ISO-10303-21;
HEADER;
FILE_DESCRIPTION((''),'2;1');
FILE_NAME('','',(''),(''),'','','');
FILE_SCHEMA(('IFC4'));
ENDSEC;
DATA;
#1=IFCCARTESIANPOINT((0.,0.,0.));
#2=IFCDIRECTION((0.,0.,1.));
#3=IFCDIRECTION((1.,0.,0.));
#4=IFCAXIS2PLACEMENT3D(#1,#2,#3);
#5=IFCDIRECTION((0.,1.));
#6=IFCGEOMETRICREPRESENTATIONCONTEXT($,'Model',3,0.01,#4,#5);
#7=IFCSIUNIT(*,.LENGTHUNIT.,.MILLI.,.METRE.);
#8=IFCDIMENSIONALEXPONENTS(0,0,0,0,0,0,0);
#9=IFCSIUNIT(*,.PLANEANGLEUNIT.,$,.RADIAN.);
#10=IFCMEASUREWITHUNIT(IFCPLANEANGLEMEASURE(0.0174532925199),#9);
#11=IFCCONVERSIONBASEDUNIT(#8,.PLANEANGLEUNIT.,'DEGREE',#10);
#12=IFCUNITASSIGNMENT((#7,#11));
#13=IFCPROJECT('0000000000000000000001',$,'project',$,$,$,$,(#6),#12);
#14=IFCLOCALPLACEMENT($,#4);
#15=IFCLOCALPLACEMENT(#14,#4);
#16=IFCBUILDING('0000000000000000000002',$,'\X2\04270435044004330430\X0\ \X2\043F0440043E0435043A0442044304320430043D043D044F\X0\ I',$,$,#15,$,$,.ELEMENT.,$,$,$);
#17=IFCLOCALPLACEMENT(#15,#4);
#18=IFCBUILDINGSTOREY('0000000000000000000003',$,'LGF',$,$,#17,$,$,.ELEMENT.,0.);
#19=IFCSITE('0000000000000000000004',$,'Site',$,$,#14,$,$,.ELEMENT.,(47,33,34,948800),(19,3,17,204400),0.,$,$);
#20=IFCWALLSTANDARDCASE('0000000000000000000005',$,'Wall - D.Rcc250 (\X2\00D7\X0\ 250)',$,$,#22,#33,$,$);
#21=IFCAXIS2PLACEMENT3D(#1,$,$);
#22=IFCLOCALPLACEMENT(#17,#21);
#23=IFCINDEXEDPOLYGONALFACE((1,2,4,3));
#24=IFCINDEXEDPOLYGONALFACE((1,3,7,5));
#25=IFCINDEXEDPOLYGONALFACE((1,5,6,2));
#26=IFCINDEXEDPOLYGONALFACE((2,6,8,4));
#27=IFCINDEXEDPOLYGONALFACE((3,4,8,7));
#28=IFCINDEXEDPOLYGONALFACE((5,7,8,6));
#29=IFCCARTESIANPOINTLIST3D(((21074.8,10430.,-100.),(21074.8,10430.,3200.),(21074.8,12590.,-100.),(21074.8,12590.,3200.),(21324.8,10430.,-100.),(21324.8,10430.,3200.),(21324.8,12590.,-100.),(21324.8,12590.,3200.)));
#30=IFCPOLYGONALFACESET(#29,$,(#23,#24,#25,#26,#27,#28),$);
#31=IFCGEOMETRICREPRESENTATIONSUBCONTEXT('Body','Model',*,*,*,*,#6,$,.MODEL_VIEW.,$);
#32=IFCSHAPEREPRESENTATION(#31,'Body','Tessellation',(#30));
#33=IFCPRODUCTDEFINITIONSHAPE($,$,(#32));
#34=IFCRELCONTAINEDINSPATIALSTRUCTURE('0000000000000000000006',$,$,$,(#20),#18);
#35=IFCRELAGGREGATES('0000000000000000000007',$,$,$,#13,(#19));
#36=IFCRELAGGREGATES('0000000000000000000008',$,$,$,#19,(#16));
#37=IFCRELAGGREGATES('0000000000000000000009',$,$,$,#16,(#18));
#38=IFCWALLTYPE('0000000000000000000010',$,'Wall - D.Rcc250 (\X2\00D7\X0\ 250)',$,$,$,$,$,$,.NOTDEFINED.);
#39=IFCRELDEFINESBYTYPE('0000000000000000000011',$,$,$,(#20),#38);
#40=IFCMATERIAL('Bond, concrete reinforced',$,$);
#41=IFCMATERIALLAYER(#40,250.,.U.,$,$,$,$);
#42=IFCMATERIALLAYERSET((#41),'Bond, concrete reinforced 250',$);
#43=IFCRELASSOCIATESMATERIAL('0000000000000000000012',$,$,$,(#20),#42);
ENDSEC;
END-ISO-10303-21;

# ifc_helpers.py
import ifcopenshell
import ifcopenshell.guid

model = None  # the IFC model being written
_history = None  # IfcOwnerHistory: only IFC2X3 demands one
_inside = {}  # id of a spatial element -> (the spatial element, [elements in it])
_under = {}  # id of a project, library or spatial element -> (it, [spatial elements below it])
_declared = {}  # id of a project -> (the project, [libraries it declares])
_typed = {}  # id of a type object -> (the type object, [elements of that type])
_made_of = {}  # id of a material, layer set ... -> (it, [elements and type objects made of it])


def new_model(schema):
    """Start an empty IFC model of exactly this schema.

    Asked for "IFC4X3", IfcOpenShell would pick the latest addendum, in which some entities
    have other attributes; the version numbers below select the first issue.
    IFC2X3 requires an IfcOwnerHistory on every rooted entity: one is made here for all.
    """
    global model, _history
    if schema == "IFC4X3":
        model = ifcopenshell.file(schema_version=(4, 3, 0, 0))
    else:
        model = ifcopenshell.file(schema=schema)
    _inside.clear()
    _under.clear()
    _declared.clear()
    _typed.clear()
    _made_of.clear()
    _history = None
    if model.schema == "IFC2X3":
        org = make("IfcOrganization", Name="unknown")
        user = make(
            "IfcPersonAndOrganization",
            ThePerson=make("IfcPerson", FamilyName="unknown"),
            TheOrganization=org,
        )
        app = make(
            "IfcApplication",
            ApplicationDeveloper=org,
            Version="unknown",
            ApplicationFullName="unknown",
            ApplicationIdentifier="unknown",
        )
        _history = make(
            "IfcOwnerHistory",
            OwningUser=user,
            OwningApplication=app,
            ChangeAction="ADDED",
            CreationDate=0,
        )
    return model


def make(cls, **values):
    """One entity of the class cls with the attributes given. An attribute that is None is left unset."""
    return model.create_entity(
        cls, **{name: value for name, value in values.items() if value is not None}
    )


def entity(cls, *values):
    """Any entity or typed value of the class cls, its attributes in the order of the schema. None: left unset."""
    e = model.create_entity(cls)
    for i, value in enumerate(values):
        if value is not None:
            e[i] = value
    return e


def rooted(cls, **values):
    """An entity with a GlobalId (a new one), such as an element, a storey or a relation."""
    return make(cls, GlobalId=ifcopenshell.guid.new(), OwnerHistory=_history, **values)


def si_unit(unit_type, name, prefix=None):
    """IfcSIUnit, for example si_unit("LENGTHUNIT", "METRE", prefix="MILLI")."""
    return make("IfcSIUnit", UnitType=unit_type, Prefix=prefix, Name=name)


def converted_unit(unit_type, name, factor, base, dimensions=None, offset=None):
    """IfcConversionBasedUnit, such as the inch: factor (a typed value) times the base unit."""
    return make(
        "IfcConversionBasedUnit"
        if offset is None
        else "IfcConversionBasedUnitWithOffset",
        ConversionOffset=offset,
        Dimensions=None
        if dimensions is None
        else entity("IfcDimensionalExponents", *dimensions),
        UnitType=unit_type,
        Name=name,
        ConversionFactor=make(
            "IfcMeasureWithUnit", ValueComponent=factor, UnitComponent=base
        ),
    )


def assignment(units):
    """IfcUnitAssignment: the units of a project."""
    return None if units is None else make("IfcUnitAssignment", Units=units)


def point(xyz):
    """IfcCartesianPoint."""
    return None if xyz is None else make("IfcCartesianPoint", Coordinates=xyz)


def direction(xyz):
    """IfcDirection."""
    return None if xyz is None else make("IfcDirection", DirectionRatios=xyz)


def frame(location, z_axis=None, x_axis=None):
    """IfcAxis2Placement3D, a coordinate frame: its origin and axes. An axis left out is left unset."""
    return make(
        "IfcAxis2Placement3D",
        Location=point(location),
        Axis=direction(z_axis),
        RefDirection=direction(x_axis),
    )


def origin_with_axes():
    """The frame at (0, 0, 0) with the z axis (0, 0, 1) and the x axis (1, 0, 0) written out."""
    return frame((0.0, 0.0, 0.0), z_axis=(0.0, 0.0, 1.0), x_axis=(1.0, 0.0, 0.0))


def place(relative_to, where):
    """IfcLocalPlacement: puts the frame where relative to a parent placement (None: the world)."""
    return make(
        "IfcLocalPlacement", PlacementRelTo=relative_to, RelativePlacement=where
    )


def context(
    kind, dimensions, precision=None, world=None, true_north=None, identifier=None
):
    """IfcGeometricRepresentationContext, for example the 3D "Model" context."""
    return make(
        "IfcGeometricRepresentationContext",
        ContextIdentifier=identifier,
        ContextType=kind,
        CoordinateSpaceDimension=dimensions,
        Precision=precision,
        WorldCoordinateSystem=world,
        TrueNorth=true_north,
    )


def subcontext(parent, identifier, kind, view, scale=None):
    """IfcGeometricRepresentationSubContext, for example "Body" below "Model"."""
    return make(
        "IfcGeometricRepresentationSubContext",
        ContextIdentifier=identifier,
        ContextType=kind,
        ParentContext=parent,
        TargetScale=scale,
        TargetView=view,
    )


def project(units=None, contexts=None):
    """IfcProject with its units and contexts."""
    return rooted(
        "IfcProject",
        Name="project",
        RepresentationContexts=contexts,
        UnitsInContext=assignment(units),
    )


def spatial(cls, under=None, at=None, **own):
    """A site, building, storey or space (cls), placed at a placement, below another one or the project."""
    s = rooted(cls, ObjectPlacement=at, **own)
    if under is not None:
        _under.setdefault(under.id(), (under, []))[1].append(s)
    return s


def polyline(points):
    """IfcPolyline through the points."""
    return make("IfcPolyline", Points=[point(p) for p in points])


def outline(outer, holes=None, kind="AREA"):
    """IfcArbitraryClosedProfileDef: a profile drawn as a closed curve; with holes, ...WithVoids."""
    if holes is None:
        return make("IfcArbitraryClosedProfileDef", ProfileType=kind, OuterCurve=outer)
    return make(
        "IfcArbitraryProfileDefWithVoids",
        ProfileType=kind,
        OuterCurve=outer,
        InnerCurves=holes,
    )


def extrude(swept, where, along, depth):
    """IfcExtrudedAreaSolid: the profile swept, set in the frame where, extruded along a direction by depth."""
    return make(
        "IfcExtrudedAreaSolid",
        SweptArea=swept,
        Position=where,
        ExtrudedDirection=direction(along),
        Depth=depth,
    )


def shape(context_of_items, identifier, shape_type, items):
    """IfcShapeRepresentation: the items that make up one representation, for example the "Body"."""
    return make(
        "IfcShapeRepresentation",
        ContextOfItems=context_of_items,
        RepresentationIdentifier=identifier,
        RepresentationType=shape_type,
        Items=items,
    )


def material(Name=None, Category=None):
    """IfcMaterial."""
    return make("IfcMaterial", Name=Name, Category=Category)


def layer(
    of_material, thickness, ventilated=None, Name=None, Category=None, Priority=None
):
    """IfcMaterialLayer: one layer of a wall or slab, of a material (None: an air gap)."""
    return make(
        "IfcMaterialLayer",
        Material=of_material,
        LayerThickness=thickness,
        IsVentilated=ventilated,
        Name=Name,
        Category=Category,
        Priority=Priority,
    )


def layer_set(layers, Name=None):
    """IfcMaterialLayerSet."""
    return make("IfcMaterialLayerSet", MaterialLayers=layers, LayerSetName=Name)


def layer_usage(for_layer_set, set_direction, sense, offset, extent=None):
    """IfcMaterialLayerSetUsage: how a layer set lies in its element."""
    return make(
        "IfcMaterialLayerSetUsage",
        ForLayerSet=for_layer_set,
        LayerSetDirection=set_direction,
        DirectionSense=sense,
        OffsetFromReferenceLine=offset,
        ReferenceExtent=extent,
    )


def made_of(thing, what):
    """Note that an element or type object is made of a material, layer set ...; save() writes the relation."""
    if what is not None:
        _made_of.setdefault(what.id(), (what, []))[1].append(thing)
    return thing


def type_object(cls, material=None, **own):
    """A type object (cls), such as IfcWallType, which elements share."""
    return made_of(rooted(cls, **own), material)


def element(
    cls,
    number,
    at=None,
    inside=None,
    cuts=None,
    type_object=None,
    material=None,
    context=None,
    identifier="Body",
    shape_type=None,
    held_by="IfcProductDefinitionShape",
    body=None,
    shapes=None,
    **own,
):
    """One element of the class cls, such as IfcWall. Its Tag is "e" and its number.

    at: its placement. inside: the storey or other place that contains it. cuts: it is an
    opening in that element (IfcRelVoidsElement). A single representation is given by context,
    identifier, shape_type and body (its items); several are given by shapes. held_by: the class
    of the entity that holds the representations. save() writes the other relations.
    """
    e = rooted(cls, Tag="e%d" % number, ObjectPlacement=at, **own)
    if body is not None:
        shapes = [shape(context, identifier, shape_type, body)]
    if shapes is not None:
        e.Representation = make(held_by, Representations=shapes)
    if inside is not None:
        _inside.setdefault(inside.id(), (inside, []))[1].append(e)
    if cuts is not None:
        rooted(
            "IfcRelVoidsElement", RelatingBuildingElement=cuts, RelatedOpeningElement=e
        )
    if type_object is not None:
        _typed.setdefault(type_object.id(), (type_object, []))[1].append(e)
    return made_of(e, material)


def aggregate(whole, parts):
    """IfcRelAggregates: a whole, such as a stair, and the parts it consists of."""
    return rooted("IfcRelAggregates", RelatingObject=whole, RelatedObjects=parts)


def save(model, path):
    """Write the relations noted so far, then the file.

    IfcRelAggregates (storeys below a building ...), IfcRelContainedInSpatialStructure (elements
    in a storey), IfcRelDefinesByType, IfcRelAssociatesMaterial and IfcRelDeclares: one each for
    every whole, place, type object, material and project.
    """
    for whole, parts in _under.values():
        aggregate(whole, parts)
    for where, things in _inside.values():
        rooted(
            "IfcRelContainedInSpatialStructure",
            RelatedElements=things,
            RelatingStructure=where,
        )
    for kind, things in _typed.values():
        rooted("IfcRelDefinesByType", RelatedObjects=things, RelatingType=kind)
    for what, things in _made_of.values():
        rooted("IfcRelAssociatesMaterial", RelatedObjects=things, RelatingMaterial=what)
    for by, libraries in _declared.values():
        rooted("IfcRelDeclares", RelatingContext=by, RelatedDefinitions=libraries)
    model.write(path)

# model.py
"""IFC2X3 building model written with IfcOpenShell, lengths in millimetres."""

from ifc_helpers import new_model, entity, si_unit, converted_unit, direction, frame, origin_with_axes, place, context, subcontext, project, spatial, polyline, outline, extrude, material, layer, layer_set, layer_usage, type_object, element, save


model = new_model("IFC2X3")

# Units and contexts
model_context = context("Model", 3, precision=0.01, world=origin_with_axes(), true_north=direction((0.0, 1.0)))
body_context = subcontext(model_context, "Body", "Model", "MODEL_VIEW")
ifc_project = project(units=[si_unit("LENGTHUNIT", "METRE", prefix="MILLI"), converted_unit("PLANEANGLEUNIT", "DEGREE", entity("IfcPlaneAngleMeasure", 0.0174532925199), si_unit("PLANEANGLEUNIT", "RADIAN"), dimensions=[0, 0, 0, 0, 0, 0, 0])], contexts=[model_context])

# Site, building, storey
site_placement = place(None, origin_with_axes())
site = spatial("IfcSite", under=ifc_project, at=site_placement, Name="Site", CompositionType="ELEMENT", RefLatitude=(47, 33, 34, 948800), RefLongitude=(19, 3, 17, 204400), RefElevation=0.0)
building_placement = place(site_placement, origin_with_axes())
building = spatial("IfcBuilding", under=site, at=building_placement, Name="Черга проектування I", CompositionType="ELEMENT")
storey_placement = place(building_placement, origin_with_axes())
storey = spatial("IfcBuildingStorey", under=building, at=storey_placement, Name="LGF", CompositionType="ELEMENT", Elevation=0.0)

# Shared definitions
ifc_material = material(Name="Bond, concrete reinforced")

# Shared definitions
wall_type_1 = type_object("IfcWallType", Name="Wall - D.Rcc250 (× 250)", PredefinedType="NOTDEFINED")

# Wall
ifc_layer_1 = layer(ifc_material, 250.0, ventilated="UNKNOWN")
ifc_layer_set_1 = layer_set([ifc_layer_1], Name="Bond, concrete reinforced 250")
ifc_layer_usage_1 = layer_usage(ifc_layer_set_1, "AXIS2", "POSITIVE", -250.0)
wall_1_placement = place(storey_placement, frame((21074.8, 10430.0, -100.0), z_axis=(0.0, 0.0, 1.0), x_axis=(0.0, 1.0, 0.0)))
element("IfcWallStandardCase", 1, at=wall_1_placement, inside=storey, type_object=wall_type_1, material=ifc_layer_usage_1, Name="Wall - D.Rcc250 (× 250)", context=body_context, shape_type="SweptSolid", body=[
    extrude(outline(polyline([(0.0, -250.0), (2160.0, -250.0), (2160.0, 0.0), (0.0, 0.0), (0.0, -250.0)])), origin_with_axes(), (0.0, 0.0, 1.0), 3300.0),
])

save(model, "model.ifc")
